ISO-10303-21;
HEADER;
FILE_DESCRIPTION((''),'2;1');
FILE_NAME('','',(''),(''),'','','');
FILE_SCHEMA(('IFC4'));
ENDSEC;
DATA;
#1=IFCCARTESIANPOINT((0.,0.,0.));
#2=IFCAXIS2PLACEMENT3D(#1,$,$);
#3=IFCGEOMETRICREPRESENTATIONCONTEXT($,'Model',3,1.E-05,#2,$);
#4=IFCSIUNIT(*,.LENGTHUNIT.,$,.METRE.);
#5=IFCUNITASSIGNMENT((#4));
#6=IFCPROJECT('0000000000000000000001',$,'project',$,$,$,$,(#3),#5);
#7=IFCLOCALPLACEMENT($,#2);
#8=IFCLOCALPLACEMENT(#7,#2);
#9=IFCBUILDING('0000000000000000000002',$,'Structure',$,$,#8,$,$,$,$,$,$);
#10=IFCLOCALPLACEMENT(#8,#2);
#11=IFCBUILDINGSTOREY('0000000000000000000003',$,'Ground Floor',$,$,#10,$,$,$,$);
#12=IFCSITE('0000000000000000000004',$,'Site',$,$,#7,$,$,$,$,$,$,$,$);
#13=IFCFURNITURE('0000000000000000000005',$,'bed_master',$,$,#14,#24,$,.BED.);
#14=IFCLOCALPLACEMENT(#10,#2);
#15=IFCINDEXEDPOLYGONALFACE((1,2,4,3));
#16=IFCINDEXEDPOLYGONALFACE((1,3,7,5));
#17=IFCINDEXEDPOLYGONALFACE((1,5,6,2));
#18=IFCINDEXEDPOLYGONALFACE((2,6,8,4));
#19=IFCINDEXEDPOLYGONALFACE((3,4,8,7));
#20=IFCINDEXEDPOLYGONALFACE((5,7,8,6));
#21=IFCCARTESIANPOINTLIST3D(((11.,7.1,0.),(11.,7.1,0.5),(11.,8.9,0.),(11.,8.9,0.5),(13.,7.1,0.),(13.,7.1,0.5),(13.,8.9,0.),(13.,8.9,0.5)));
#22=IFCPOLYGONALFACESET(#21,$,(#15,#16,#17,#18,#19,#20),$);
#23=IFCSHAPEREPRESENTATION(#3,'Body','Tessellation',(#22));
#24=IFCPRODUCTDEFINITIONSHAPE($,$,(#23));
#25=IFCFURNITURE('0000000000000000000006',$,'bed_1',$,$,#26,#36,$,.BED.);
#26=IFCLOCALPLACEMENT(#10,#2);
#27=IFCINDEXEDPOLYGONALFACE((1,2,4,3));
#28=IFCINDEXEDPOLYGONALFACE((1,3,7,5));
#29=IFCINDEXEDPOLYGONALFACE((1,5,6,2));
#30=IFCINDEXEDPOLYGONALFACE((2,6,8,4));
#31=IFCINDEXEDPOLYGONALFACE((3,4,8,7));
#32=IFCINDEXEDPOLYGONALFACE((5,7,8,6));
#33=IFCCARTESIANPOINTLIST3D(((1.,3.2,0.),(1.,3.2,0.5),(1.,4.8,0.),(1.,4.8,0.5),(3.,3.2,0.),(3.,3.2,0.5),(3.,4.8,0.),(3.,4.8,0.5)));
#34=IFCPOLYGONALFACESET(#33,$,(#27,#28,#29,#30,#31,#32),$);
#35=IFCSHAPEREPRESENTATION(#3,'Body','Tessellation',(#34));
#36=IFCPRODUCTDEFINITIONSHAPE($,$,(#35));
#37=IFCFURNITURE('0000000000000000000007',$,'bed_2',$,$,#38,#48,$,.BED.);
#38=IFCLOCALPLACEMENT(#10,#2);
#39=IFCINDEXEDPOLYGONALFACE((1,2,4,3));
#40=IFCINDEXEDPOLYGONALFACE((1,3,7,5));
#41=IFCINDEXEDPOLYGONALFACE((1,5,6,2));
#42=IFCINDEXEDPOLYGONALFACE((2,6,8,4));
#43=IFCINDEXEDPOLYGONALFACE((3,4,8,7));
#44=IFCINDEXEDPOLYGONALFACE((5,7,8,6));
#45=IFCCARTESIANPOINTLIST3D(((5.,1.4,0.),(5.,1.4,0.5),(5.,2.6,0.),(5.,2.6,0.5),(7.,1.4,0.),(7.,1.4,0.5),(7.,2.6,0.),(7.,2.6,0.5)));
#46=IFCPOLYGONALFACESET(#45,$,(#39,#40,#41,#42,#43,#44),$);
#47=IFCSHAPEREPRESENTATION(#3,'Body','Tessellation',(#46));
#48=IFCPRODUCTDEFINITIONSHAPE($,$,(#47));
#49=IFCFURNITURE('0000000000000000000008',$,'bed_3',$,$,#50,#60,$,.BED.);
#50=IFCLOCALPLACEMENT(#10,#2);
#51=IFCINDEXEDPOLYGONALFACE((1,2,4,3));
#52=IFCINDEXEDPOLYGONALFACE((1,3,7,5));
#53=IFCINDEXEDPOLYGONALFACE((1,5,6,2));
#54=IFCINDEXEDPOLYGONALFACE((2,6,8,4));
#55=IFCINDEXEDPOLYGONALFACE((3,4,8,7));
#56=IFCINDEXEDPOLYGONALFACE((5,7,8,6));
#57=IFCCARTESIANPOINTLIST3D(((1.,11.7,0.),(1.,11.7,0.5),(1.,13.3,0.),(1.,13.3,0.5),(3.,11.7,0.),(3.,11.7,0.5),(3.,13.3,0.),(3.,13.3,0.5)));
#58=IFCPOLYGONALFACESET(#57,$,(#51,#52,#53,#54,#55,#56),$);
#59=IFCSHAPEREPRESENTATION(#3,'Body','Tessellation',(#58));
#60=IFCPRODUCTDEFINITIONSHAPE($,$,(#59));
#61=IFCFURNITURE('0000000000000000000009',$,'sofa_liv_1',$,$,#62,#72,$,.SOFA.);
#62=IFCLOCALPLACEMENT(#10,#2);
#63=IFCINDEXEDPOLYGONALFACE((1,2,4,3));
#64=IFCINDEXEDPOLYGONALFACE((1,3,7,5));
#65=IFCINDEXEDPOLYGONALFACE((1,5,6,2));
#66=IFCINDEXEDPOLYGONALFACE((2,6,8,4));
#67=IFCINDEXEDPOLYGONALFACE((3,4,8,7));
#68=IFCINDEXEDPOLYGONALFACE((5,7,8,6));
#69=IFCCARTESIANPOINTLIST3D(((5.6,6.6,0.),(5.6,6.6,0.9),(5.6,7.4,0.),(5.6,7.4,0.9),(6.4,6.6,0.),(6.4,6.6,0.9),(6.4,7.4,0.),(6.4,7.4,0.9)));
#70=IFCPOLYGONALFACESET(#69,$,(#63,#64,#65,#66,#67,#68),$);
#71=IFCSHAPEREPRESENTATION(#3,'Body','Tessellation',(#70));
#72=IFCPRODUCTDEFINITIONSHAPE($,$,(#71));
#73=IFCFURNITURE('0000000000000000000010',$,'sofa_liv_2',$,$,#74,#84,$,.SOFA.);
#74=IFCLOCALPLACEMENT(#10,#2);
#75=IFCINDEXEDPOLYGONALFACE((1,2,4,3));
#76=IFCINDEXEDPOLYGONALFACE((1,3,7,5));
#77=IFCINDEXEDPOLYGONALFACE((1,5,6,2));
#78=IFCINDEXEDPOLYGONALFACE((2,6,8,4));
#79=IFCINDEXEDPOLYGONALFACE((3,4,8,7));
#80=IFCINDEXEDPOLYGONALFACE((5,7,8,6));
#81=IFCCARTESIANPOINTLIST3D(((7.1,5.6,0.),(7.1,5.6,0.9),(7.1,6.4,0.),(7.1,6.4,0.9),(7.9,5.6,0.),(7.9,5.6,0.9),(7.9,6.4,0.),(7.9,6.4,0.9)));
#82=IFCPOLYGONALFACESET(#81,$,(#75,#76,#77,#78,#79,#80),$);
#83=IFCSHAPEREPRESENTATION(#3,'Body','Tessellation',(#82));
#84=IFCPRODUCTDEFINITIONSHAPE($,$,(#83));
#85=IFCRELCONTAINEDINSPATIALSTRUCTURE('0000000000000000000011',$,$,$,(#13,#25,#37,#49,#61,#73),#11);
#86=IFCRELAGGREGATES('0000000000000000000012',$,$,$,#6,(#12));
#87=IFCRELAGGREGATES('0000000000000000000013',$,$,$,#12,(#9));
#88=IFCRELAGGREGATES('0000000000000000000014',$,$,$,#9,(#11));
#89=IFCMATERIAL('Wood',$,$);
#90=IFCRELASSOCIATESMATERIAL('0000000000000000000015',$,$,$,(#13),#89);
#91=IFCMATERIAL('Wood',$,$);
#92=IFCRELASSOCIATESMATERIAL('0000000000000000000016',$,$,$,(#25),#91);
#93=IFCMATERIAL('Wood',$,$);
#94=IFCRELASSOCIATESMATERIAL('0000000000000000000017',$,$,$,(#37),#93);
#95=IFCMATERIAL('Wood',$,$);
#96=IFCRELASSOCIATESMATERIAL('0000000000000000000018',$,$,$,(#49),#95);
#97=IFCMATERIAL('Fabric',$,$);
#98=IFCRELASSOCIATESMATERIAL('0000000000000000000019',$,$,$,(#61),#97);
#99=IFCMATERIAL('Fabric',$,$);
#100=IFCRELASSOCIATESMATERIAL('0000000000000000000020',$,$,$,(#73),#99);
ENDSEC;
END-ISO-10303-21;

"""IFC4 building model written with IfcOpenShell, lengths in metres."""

from ifc_helpers import new_model, si_unit, frame, origin, place, context, project, spatial, polyline, outline, extrude, material, element, save


model = new_model("IFC4")

# Units and contexts
model_context = context("Model", 3, precision=1e-05, world=origin())
ifc_project = project(units=[si_unit("LENGTHUNIT", "METRE")], contexts=[model_context])

# Site, building, storey
site_placement = place(None, origin())
site = spatial("IfcSite", under=ifc_project, at=site_placement, Name="Site")
building_placement = place(site_placement, origin())
building = spatial("IfcBuilding", under=site, at=building_placement, Name="Structure")
storey_placement = place(building_placement, origin())
storey = spatial("IfcBuildingStorey", under=building, at=storey_placement, Name="Ground Floor")

# Furniture
ifc_material_1 = material(Name="Wood")
furniture_1_placement = place(storey_placement, frame((12.0, 8.0, 0.0)))
element("IfcFurniture", 1, at=furniture_1_placement, inside=storey, material=ifc_material_1, Name="bed_master", PredefinedType="BED", context=model_context, shape_type="SweptSolid", body=[
    extrude(outline(polyline([(-1.0, -0.9), (1.0, -0.9), (1.0, 0.9), (-1.0, 0.9), (-1.0, -0.9)])), origin(), (0.0, 0.0, 1.0), 0.5),
])
ifc_material_2 = material(Name="Wood")
furniture_2_placement = place(storey_placement, frame((2.0, 4.0, 0.0)))
element("IfcFurniture", 2, at=furniture_2_placement, inside=storey, material=ifc_material_2, Name="bed_1", PredefinedType="BED", context=model_context, shape_type="SweptSolid", body=[
    extrude(outline(polyline([(-1.0, -0.8), (1.0, -0.8), (1.0, 0.8), (-1.0, 0.8), (-1.0, -0.8)])), origin(), (0.0, 0.0, 1.0), 0.5),
])
ifc_material_3 = material(Name="Wood")
furniture_3_placement = place(storey_placement, frame((6.0, 2.0, 0.0)))
element("IfcFurniture", 3, at=furniture_3_placement, inside=storey, material=ifc_material_3, Name="bed_2", PredefinedType="BED", context=model_context, shape_type="SweptSolid", body=[
    extrude(outline(polyline([(-1.0, -0.6), (1.0, -0.6), (1.0, 0.6), (-1.0, 0.6), (-1.0, -0.6)])), origin(), (0.0, 0.0, 1.0), 0.5),
])
ifc_material_4 = material(Name="Wood")
furniture_4_placement = place(storey_placement, frame((2.0, 12.5, 0.0)))
element("IfcFurniture", 4, at=furniture_4_placement, inside=storey, material=ifc_material_4, Name="bed_3", PredefinedType="BED", context=model_context, shape_type="SweptSolid", body=[
    extrude(outline(polyline([(-1.0, -0.8), (1.0, -0.8), (1.0, 0.8), (-1.0, 0.8), (-1.0, -0.8)])), origin(), (0.0, 0.0, 1.0), 0.5),
])
ifc_material_5 = material(Name="Fabric")
furniture_5_placement = place(storey_placement, frame((6.0, 7.0, 0.0)))
element("IfcFurniture", 5, at=furniture_5_placement, inside=storey, material=ifc_material_5, Name="sofa_liv_1", PredefinedType="SOFA", context=model_context, shape_type="SweptSolid", body=[
    extrude(outline(polyline([(-0.4, -0.4), (0.4, -0.4), (0.4, 0.4), (-0.4, 0.4), (-0.4, -0.4)])), origin(), (0.0, 0.0, 1.0), 0.9),
])
ifc_material_6 = material(Name="Fabric")
furniture_6_placement = place(storey_placement, frame((7.5, 6.0, 0.0)))
element("IfcFurniture", 6, at=furniture_6_placement, inside=storey, material=ifc_material_6, Name="sofa_liv_2", PredefinedType="SOFA", context=model_context, shape_type="SweptSolid", body=[
    extrude(outline(polyline([(-0.4, -0.4), (0.4, -0.4), (0.4, 0.4), (-0.4, 0.4), (-0.4, -0.4)])), origin(), (0.0, 0.0, 1.0), 0.9),
])

save(model, "model.ifc")
